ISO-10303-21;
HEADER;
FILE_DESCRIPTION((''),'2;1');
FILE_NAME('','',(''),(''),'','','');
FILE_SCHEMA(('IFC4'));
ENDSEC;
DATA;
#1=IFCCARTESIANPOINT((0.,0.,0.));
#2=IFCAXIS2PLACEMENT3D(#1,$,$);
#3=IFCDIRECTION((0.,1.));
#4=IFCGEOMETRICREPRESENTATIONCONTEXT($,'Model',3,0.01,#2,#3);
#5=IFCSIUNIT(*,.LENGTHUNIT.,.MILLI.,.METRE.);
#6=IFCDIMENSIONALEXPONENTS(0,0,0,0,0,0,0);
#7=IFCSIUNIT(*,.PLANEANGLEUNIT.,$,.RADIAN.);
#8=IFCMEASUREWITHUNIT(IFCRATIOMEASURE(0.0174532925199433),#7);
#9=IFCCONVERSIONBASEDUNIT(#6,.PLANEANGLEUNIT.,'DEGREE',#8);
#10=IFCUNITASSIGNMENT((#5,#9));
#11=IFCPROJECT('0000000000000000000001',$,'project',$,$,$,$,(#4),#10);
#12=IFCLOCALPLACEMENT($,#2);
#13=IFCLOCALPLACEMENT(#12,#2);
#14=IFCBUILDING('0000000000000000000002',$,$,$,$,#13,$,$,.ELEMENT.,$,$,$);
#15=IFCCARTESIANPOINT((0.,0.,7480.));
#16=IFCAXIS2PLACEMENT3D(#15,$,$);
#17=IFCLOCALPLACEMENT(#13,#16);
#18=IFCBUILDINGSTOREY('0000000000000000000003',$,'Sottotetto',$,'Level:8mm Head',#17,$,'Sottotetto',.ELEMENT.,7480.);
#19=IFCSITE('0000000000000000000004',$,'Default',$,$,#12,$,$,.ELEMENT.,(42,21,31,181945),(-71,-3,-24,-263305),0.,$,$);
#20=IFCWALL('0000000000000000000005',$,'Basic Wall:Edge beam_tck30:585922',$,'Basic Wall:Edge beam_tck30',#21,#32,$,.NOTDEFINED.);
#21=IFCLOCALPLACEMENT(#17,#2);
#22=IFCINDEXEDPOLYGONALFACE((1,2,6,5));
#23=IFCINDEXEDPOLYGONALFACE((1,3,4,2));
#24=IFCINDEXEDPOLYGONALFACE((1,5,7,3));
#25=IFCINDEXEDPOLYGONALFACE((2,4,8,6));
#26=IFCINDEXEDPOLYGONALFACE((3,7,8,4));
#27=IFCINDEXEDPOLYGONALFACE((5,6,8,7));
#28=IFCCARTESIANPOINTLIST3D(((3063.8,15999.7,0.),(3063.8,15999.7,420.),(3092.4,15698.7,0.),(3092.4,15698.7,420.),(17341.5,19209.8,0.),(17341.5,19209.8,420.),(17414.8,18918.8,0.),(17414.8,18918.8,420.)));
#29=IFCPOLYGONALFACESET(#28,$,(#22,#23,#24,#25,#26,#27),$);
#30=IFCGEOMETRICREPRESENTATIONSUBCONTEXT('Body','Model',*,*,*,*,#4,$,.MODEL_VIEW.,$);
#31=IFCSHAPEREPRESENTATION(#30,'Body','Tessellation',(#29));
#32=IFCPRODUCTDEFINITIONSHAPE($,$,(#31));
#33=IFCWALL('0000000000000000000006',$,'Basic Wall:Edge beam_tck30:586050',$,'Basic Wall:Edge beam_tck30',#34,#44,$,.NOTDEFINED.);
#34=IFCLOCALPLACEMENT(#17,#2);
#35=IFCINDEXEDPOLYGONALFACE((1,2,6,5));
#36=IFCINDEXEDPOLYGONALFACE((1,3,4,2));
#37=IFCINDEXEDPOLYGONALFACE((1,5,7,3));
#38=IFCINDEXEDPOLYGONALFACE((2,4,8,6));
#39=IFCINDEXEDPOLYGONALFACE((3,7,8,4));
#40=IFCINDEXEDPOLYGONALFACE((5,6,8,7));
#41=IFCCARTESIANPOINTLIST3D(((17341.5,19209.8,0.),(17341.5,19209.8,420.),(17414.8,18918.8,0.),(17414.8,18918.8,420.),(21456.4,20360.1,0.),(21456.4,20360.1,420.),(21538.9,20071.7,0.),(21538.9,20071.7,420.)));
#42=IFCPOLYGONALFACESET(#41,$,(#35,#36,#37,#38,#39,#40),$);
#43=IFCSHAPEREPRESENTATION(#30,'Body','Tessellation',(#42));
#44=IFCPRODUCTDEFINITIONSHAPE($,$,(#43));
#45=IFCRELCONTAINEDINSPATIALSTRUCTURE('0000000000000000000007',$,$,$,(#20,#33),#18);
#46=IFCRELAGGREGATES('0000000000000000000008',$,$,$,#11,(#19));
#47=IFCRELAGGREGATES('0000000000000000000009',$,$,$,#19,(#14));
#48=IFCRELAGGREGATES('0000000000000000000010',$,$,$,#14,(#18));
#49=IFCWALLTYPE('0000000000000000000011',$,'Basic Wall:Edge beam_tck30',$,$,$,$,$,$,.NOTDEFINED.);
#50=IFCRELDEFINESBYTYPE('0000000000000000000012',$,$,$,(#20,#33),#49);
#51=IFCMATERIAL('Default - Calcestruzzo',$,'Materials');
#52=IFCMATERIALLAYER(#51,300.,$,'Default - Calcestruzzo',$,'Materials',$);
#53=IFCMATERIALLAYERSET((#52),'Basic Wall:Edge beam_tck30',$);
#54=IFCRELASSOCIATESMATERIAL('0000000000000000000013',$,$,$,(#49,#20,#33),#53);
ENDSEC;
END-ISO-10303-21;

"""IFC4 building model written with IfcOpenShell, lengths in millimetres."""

from ifc_helpers import new_model, entity, si_unit, converted_unit, direction, frame, origin, place, context, subcontext, project, spatial, polyline, outline, extrude, material, layer, layer_set, layer_usage, type_object, element, save


model = new_model("IFC4")

# Units and contexts
model_context = context("Model", 3, precision=0.01, world=origin(), true_north=direction((0.0, 1.0)))
body_context = subcontext(model_context, "Body", "Model", "MODEL_VIEW")
ifc_project = project(units=[si_unit("LENGTHUNIT", "METRE", prefix="MILLI"), converted_unit("PLANEANGLEUNIT", "DEGREE", entity("IfcRatioMeasure", 0.0174532925199433), si_unit("PLANEANGLEUNIT", "RADIAN"), dimensions=[0, 0, 0, 0, 0, 0, 0])], contexts=[model_context])

# Site, building, storey
site_placement = place(None, origin())
site = spatial("IfcSite", under=ifc_project, at=site_placement, Name="Default", CompositionType="ELEMENT", RefLatitude=(42, 21, 31, 181945), RefLongitude=(-71, -3, -24, -263305), RefElevation=0.0)
building_placement = place(site_placement, origin())
building = spatial("IfcBuilding", under=site, at=building_placement, CompositionType="ELEMENT")
storey_placement = place(building_placement, frame((0.0, 0.0, 7480.0)))
storey = spatial("IfcBuildingStorey", under=building, at=storey_placement, Name="Sottotetto", ObjectType="Level:8mm Head", LongName="Sottotetto", CompositionType="ELEMENT", Elevation=7480.0)

# Walls
ifc_material_1 = material(Name="Default - Calcestruzzo", Category="Materials")
ifc_layer_1 = layer(ifc_material_1, 300.0, Name="Default - Calcestruzzo", Category="Materials")
ifc_layer_set_1 = layer_set([ifc_layer_1], Name="Basic Wall:Edge beam_tck30")
wall_type = type_object("IfcWallType", Name="Basic Wall:Edge beam_tck30", PredefinedType="NOTDEFINED", material=ifc_layer_set_1)
ifc_layer_usage_1 = layer_usage(ifc_layer_set_1, "AXIS2", "NEGATIVE", 150.0)
wall_1_placement = place(storey_placement, frame((3059.4, 15845.0, 0.0), z_axis=(0.0, 0.0, 1.0), x_axis=(0.975645, 0.219355, 0.0)))
element("IfcWall", 1, at=wall_1_placement, inside=storey, type_object=wall_type, material=ifc_layer_usage_1, Name="Basic Wall:Edge beam_tck30:585922", ObjectType="Basic Wall:Edge beam_tck30", PredefinedType="NOTDEFINED", context=body_context, shape_type="SweptSolid", body=[
    extrude(outline(polyline([(14680.0, -150.0), (14672.3, 150.0), (38.2, 150.0), (0.0, -150.0), (14680.0, -150.0)])), origin(), (0.0, 0.0, 1.0), 420.0),
])
ifc_layer_usage_2 = layer_usage(ifc_layer_set_1, "AXIS2", "NEGATIVE", 150.0)
wall_2_placement = place(storey_placement, frame((17374.4, 19063.2, 0.0), z_axis=(0.0, 0.0, 1.0), x_axis=(0.963076, 0.26923, 0.0)))
element("IfcWall", 2, at=wall_2_placement, inside=storey, type_object=wall_type, material=ifc_layer_usage_2, Name="Basic Wall:Edge beam_tck30:586050", ObjectType="Basic Wall:Edge beam_tck30", PredefinedType="NOTDEFINED", context=body_context, shape_type="SweptSolid", body=[
    extrude(outline(polyline([(4282.2, -150.0), (4280.4, 150.0), (7.7, 150.0), (0.0, -150.0), (4282.2, -150.0)])), origin(), (0.0, 0.0, 1.0), 420.0),
])

save(model, "model.ifc")
